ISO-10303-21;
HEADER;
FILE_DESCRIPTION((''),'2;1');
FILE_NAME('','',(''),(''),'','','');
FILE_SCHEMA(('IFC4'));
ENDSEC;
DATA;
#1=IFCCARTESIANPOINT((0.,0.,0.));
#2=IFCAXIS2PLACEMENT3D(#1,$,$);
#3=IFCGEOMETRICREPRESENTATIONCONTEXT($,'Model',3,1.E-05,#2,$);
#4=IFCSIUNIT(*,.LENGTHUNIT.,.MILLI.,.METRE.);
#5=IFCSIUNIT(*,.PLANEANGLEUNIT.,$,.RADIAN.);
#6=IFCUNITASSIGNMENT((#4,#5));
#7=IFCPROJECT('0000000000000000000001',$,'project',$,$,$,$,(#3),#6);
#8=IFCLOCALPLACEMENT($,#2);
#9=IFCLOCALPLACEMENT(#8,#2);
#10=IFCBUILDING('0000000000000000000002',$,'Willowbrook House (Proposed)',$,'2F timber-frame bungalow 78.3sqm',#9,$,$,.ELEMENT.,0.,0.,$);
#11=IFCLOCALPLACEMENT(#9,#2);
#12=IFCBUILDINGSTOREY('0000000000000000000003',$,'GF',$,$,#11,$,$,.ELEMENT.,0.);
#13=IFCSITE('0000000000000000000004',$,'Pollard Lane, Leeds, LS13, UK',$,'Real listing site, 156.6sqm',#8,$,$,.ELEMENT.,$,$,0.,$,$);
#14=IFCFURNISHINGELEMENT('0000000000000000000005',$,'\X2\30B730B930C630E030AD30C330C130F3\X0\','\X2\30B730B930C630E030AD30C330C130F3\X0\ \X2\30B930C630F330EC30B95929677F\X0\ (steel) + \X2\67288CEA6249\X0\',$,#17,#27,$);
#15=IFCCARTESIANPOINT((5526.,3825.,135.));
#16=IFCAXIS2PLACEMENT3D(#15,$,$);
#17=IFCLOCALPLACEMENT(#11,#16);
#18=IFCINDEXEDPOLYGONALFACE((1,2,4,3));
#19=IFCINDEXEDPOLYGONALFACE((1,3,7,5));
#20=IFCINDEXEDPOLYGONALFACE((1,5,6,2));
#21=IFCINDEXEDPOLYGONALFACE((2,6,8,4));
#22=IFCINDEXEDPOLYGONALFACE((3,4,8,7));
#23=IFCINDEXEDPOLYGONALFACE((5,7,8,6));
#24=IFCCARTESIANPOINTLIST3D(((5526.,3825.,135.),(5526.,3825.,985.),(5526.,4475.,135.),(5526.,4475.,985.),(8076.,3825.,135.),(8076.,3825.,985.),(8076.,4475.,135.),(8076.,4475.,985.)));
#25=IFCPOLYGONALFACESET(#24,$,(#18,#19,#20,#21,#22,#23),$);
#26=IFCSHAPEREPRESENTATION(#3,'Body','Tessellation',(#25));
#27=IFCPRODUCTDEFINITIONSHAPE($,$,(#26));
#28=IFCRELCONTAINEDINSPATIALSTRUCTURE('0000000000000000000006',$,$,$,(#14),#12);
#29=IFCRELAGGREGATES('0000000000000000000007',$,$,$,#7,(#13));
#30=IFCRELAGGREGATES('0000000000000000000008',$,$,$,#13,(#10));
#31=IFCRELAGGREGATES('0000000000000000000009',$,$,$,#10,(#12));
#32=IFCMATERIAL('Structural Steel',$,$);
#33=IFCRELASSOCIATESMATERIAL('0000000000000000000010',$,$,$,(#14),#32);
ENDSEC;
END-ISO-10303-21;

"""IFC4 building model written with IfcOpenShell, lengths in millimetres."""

from ifc_helpers import new_model, si_unit, frame, frame_2d, origin, place, context, project, spatial, rectangle, extrude, material, element, save


model = new_model("IFC4")

# Units and contexts
model_context = context("Model", 3, precision=1e-05, world=origin())
ifc_project = project(units=[si_unit("LENGTHUNIT", "METRE", prefix="MILLI"), si_unit("PLANEANGLEUNIT", "RADIAN")], contexts=[model_context])

# Site, building, storey
site_placement = place(None, origin())
site = spatial("IfcSite", under=ifc_project, at=site_placement, Name="Pollard Lane, Leeds, LS13, UK", ObjectType="Real listing site, 156.6sqm", CompositionType="ELEMENT", RefElevation=0.0)
building_placement = place(site_placement, origin())
building = spatial("IfcBuilding", under=site, at=building_placement, Name="Willowbrook House (Proposed)", ObjectType="2F timber-frame bungalow 78.3sqm", CompositionType="ELEMENT", ElevationOfRefHeight=0.0, ElevationOfTerrain=0.0)
storey_placement = place(building_placement, origin())
storey = spatial("IfcBuildingStorey", under=building, at=storey_placement, Name="GF", CompositionType="ELEMENT", Elevation=0.0)

# Furnishing element
ifc_material_1 = material(Name="Structural Steel")
furnishing_1_placement = place(storey_placement, frame((5526.0, 3825.0, 135.0)))
element("IfcFurnishingElement", 1, at=furnishing_1_placement, inside=storey, material=ifc_material_1, Name="システムキッチン", Description="システムキッチン ステンレス天板 (steel) + 木質扉", context=model_context, shape_type="SweptSolid", body=[
    extrude(rectangle(XDim=2550.0, YDim=650.0, at=frame_2d((1275.0, 325.0))), frame((5526.0, 3825.0, 135.0)), (0.0, 0.0, 1.0), 850.0),
])

save(model, "model.ifc")
